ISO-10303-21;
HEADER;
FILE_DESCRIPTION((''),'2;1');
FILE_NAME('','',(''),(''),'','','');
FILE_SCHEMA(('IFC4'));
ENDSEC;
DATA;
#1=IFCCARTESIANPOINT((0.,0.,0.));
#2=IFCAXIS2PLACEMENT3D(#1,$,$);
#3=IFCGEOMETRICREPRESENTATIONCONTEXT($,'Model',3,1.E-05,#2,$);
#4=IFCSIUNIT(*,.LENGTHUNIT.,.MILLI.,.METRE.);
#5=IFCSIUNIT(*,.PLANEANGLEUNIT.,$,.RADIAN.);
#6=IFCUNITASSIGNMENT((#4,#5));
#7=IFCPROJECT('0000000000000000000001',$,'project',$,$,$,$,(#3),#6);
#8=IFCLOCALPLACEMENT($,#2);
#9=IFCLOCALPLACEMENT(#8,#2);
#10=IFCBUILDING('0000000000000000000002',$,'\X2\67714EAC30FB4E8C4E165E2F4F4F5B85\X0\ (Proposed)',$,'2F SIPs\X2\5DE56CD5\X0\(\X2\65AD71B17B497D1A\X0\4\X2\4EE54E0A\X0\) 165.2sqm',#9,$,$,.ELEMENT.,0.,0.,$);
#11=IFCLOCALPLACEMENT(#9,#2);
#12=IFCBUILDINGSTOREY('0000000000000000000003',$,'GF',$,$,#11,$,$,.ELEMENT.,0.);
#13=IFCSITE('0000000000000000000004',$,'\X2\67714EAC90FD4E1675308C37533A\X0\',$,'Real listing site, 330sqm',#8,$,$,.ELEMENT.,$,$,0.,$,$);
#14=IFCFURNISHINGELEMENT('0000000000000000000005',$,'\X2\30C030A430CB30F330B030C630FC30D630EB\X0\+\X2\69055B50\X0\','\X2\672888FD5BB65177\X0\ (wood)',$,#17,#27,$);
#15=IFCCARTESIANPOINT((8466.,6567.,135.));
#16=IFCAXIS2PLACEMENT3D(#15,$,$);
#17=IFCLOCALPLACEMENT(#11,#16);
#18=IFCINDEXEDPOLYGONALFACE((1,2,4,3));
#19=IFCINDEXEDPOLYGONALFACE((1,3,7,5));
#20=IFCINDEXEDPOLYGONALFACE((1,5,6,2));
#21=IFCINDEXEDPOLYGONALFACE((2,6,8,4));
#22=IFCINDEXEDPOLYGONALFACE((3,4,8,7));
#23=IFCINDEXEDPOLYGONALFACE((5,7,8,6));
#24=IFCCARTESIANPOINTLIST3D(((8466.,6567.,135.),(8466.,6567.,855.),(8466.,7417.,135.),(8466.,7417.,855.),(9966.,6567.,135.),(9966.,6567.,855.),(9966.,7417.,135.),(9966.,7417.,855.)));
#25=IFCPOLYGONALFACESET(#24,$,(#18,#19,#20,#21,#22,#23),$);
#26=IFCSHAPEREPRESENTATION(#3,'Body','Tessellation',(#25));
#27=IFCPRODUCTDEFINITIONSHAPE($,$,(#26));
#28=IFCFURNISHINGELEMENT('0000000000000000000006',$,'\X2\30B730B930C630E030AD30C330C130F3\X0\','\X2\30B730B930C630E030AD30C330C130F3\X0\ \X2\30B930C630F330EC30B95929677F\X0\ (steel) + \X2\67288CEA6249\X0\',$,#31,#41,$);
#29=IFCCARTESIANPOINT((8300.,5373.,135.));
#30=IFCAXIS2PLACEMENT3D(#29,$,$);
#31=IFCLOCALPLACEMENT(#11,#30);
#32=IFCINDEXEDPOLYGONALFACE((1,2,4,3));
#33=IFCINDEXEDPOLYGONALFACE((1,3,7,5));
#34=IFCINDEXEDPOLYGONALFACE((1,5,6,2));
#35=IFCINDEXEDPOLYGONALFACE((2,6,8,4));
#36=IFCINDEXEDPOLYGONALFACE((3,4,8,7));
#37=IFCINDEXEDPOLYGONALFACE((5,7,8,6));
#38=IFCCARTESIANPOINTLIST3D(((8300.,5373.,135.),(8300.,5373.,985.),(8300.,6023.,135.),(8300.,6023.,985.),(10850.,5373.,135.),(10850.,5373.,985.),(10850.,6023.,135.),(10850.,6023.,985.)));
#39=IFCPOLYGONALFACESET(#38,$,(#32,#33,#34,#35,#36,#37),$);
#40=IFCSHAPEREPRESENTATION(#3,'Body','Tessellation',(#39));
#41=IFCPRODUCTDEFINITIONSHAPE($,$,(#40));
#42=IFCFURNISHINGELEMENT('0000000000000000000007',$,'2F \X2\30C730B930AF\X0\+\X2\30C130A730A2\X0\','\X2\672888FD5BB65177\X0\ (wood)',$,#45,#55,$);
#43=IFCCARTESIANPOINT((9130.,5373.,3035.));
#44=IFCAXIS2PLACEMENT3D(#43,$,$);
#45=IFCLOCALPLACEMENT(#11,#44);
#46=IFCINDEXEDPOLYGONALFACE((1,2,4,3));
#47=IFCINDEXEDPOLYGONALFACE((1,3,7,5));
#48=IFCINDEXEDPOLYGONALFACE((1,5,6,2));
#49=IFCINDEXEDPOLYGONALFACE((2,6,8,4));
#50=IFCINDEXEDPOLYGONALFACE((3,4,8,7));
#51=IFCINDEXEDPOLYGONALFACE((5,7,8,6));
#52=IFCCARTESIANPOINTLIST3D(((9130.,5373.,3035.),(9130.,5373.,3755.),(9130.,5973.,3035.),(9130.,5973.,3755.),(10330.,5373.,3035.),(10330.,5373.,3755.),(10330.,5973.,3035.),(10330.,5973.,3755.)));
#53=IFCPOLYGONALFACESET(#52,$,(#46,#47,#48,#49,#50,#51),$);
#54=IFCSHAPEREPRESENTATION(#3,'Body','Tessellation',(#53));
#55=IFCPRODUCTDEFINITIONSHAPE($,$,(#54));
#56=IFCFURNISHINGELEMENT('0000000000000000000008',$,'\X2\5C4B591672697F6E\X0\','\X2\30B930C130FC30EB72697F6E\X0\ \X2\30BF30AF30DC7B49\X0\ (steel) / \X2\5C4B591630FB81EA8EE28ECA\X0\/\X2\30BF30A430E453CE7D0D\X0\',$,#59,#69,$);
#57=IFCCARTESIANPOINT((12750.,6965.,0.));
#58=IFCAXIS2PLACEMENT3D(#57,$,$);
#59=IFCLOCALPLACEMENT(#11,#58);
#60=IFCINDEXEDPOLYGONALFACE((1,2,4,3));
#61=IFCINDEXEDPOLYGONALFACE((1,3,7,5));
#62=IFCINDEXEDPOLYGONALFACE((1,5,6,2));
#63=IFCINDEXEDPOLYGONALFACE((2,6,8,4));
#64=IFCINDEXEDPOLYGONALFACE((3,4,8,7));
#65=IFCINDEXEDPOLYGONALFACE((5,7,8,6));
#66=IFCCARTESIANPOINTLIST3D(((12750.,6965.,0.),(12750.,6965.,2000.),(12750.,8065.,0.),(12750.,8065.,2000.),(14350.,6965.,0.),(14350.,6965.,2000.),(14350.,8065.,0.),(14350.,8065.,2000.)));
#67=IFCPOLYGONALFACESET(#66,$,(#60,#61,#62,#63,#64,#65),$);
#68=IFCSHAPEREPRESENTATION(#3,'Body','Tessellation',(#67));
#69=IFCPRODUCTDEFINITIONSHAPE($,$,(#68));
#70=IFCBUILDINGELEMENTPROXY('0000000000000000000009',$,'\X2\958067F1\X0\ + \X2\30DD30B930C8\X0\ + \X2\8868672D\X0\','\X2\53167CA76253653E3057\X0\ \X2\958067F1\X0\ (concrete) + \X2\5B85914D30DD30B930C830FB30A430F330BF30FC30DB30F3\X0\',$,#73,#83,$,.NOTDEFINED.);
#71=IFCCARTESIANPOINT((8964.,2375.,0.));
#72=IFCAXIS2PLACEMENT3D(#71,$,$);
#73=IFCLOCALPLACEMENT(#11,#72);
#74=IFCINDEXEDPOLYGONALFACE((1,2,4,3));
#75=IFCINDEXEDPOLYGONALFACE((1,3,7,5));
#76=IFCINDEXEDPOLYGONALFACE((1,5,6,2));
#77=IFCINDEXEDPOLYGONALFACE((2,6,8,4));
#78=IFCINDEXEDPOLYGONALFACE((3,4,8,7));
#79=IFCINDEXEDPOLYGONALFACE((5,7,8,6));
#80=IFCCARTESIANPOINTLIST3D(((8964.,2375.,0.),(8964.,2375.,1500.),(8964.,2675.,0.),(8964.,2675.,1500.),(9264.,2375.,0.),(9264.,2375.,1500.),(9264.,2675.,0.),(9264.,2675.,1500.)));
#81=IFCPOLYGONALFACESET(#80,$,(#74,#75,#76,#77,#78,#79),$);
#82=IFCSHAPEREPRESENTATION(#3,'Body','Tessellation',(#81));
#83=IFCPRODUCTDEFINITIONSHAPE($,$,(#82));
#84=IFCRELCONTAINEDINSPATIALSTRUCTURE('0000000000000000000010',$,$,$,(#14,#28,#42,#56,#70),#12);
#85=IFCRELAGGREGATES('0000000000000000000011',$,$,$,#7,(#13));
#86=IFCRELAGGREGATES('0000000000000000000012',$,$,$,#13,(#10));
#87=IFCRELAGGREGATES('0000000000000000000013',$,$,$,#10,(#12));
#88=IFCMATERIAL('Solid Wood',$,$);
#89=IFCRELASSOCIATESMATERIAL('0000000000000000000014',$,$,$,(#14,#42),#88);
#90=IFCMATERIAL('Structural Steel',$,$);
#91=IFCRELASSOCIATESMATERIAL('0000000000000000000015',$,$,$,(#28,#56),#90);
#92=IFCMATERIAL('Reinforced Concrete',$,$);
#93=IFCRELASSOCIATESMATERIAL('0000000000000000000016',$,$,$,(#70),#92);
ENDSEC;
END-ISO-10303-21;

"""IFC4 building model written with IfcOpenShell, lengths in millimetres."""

from ifc_helpers import new_model, si_unit, frame, frame_2d, origin, place, context, project, spatial, rectangle, extrude, material, element, save


model = new_model("IFC4")

# Units and contexts
model_context = context("Model", 3, precision=1e-05, world=origin())
ifc_project = project(units=[si_unit("LENGTHUNIT", "METRE", prefix="MILLI"), si_unit("PLANEANGLEUNIT", "RADIAN")], contexts=[model_context])

# Site, building, storey
site_placement = place(None, origin())
site = spatial("IfcSite", under=ifc_project, at=site_placement, Name="東京都世田谷区", ObjectType="Real listing site, 330sqm", CompositionType="ELEMENT", RefElevation=0.0)
building_placement = place(site_placement, origin())
building = spatial("IfcBuilding", under=site, at=building_placement, Name="東京・二世帯住宅 (Proposed)", ObjectType="2F SIPs工法(断熱等級4以上) 165.2sqm", CompositionType="ELEMENT", ElevationOfRefHeight=0.0, ElevationOfTerrain=0.0)
storey_placement = place(building_placement, origin())
storey = spatial("IfcBuildingStorey", under=building, at=storey_placement, Name="GF", CompositionType="ELEMENT", Elevation=0.0)

# Shared definitions
ifc_material_1 = material(Name="Solid Wood")

# Shared definitions
ifc_material_2 = material(Name="Reinforced Concrete")

# Shared definitions
ifc_material_3 = material(Name="Structural Steel")

# Furnishing elements
furnishing_1_placement = place(storey_placement, frame((8466.0, 6567.0, 135.0)))
element("IfcFurnishingElement", 1, at=furnishing_1_placement, inside=storey, material=ifc_material_1, Name="ダイニングテーブル+椅子", Description="木製家具 (wood)", context=model_context, shape_type="SweptSolid", body=[
    extrude(rectangle(XDim=1500.0, YDim=850.0, at=frame_2d((750.0, 425.0))), frame((8466.0, 6567.0, 135.0)), (0.0, 0.0, 1.0), 720.0),
])
furnishing_2_placement = place(storey_placement, frame((8300.0, 5373.0, 135.0)))
element("IfcFurnishingElement", 2, at=furnishing_2_placement, inside=storey, material=ifc_material_3, Name="システムキッチン", Description="システムキッチン ステンレス天板 (steel) + 木質扉", context=model_context, shape_type="SweptSolid", body=[
    extrude(rectangle(XDim=2550.0, YDim=650.0, at=frame_2d((1275.0, 325.0))), frame((8300.0, 5373.0, 135.0)), (0.0, 0.0, 1.0), 850.0),
])
furnishing_3_placement = place(storey_placement, frame((9130.0, 5373.0, 3035.0)))
element("IfcFurnishingElement", 3, at=furnishing_3_placement, inside=storey, material=ifc_material_1, Name="2F デスク+チェア", Description="木製家具 (wood)", context=model_context, shape_type="SweptSolid", body=[
    extrude(rectangle(XDim=1200.0, YDim=600.0, at=frame_2d((600.0, 300.0))), frame((9130.0, 5373.0, 3035.0)), (0.0, 0.0, 1.0), 720.0),
])
furnishing_4_placement = place(storey_placement, frame((12750.0, 6965.0, 0.0)))
element("IfcFurnishingElement", 4, at=furnishing_4_placement, inside=storey, material=ifc_material_3, Name="屋外物置", Description="スチール物置 タクボ等 (steel) / 屋外・自転車/タイヤ収納", context=model_context, shape_type="SweptSolid", body=[
    extrude(rectangle(XDim=1600.0, YDim=1100.0, at=frame_2d((800.0, 550.0))), frame((12750.0, 6965.0, 0.0)), (0.0, 0.0, 1.0), 2000.0),
])

# Building element proxy
proxy_placement = place(storey_placement, frame((8964.0, 2375.0, 0.0)))
element("IfcBuildingElementProxy", 5, at=proxy_placement, inside=storey, material=ifc_material_2, Name="門柱 + ポスト + 表札", Description="化粧打放し 門柱 (concrete) + 宅配ポスト・インターホン", PredefinedType="NOTDEFINED", context=model_context, shape_type="SweptSolid", body=[
    extrude(rectangle(XDim=300.0, YDim=300.0, at=frame_2d((150.0, 150.0))), frame((8964.0, 2375.0, 0.0)), (0.0, 0.0, 1.0), 1500.0),
])

save(model, "model.ifc")
